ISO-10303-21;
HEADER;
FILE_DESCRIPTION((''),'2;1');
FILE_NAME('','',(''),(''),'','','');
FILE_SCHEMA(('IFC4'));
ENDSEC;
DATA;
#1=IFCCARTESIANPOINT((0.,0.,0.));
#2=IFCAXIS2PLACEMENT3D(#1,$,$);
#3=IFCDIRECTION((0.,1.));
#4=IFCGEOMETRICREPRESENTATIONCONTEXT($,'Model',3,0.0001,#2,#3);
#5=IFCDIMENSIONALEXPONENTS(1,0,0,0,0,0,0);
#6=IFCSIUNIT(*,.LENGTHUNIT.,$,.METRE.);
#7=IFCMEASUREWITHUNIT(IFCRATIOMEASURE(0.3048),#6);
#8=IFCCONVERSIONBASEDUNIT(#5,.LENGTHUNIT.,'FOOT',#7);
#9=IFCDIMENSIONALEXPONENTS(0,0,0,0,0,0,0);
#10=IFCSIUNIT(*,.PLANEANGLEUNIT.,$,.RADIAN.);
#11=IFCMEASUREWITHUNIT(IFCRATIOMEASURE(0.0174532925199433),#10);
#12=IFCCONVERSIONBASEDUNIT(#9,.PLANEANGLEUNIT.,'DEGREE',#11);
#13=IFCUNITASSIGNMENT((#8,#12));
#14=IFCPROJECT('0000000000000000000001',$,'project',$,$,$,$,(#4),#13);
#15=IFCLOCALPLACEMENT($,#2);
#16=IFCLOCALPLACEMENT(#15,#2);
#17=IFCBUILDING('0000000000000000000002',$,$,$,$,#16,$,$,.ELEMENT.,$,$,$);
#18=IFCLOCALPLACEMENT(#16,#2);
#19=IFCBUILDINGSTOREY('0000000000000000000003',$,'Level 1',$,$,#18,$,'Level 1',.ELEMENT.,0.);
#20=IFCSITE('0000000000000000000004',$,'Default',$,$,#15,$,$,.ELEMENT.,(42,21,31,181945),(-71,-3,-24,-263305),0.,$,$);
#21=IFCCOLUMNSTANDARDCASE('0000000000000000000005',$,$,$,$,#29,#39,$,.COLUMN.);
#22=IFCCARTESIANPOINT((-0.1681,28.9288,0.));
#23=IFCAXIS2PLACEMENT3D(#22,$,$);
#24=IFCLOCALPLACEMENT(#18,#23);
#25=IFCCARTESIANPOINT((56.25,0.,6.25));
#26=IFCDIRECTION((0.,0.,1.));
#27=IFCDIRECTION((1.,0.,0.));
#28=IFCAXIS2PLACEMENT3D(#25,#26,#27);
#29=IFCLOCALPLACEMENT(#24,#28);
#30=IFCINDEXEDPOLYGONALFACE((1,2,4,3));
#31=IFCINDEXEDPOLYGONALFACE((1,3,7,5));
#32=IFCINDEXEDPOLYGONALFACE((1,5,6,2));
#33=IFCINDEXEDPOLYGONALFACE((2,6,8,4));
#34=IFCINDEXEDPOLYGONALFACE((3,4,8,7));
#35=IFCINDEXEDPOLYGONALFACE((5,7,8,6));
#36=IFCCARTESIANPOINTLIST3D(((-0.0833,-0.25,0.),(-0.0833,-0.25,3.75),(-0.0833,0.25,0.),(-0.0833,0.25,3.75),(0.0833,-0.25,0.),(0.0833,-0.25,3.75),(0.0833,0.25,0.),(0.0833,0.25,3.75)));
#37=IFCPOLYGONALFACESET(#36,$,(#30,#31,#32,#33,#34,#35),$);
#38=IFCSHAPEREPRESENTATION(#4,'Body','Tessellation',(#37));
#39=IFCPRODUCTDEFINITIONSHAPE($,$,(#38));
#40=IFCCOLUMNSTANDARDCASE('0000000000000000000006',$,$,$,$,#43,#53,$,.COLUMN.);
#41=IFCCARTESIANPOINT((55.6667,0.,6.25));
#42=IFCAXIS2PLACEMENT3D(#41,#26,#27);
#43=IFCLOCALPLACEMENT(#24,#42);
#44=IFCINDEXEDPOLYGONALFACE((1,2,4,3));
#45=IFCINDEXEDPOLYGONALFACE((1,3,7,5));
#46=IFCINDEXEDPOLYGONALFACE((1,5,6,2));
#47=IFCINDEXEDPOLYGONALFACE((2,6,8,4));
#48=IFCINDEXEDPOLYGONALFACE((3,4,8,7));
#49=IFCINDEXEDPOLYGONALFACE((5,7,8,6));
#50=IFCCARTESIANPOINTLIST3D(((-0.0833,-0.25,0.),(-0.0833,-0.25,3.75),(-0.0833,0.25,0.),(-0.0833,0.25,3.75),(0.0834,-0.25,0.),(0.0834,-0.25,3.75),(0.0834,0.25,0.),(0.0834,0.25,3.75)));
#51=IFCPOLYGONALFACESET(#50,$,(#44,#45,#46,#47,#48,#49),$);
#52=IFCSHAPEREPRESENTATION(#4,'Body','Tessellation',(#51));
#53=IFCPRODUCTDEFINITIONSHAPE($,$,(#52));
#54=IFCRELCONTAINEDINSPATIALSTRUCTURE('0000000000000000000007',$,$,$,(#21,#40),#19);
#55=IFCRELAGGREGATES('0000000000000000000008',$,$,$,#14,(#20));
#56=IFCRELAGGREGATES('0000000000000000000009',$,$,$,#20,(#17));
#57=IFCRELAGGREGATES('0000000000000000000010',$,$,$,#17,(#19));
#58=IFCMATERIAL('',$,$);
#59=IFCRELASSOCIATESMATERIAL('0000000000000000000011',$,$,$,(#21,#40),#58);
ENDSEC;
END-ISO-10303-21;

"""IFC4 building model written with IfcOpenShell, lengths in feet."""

from ifc_helpers import new_model, entity, si_unit, converted_unit, direction, frame, origin, place, context, project, spatial, rectangle, extrude, material, element, save


model = new_model("IFC4")

# Units and contexts
model_context = context("Model", 3, precision=0.0001, world=origin(), true_north=direction((0.0, 1.0)))
ifc_project = project(units=[converted_unit("LENGTHUNIT", "FOOT", entity("IfcRatioMeasure", 0.3048), si_unit("LENGTHUNIT", "METRE"), dimensions=[1, 0, 0, 0, 0, 0, 0]), converted_unit("PLANEANGLEUNIT", "DEGREE", entity("IfcRatioMeasure", 0.0174532925199433), si_unit("PLANEANGLEUNIT", "RADIAN"), dimensions=[0, 0, 0, 0, 0, 0, 0])], contexts=[model_context])

# Site, building, storey
site_placement = place(None, origin())
site = spatial("IfcSite", under=ifc_project, at=site_placement, Name="Default", CompositionType="ELEMENT", RefLatitude=(42, 21, 31, 181945), RefLongitude=(-71, -3, -24, -263305), RefElevation=0.0)
building_placement = place(site_placement, origin())
building = spatial("IfcBuilding", under=site, at=building_placement, CompositionType="ELEMENT")
storey_placement = place(building_placement, origin())
storey = spatial("IfcBuildingStorey", under=building, at=storey_placement, Name="Level 1", LongName="Level 1", CompositionType="ELEMENT", Elevation=0.0)

# Columns
ifc_material = material(Name="")
placement = place(storey_placement, frame((-0.1681, 28.9288, 0.0)))
for number, where, z_axis, x_axis in (
    (1, (56.25, 0.0, 6.25), (0.0, 0.0, 1.0), (1.0, 0.0, 0.0)),
    (2, (55.6667, 0.0, 6.25), (0.0, 0.0, 1.0), (1.0, 0.0, 0.0)),
):
    element("IfcColumnStandardCase", number, at=place(placement, frame(where, z_axis=z_axis, x_axis=x_axis)), inside=storey, material=ifc_material, PredefinedType="COLUMN", context=model_context, shape_type="SweptSolid", body=[
        extrude(rectangle(XDim=0.1667, YDim=0.5), origin(), (0.0, 0.0, 1.0), 3.75),
    ])

save(model, "model.ifc")
